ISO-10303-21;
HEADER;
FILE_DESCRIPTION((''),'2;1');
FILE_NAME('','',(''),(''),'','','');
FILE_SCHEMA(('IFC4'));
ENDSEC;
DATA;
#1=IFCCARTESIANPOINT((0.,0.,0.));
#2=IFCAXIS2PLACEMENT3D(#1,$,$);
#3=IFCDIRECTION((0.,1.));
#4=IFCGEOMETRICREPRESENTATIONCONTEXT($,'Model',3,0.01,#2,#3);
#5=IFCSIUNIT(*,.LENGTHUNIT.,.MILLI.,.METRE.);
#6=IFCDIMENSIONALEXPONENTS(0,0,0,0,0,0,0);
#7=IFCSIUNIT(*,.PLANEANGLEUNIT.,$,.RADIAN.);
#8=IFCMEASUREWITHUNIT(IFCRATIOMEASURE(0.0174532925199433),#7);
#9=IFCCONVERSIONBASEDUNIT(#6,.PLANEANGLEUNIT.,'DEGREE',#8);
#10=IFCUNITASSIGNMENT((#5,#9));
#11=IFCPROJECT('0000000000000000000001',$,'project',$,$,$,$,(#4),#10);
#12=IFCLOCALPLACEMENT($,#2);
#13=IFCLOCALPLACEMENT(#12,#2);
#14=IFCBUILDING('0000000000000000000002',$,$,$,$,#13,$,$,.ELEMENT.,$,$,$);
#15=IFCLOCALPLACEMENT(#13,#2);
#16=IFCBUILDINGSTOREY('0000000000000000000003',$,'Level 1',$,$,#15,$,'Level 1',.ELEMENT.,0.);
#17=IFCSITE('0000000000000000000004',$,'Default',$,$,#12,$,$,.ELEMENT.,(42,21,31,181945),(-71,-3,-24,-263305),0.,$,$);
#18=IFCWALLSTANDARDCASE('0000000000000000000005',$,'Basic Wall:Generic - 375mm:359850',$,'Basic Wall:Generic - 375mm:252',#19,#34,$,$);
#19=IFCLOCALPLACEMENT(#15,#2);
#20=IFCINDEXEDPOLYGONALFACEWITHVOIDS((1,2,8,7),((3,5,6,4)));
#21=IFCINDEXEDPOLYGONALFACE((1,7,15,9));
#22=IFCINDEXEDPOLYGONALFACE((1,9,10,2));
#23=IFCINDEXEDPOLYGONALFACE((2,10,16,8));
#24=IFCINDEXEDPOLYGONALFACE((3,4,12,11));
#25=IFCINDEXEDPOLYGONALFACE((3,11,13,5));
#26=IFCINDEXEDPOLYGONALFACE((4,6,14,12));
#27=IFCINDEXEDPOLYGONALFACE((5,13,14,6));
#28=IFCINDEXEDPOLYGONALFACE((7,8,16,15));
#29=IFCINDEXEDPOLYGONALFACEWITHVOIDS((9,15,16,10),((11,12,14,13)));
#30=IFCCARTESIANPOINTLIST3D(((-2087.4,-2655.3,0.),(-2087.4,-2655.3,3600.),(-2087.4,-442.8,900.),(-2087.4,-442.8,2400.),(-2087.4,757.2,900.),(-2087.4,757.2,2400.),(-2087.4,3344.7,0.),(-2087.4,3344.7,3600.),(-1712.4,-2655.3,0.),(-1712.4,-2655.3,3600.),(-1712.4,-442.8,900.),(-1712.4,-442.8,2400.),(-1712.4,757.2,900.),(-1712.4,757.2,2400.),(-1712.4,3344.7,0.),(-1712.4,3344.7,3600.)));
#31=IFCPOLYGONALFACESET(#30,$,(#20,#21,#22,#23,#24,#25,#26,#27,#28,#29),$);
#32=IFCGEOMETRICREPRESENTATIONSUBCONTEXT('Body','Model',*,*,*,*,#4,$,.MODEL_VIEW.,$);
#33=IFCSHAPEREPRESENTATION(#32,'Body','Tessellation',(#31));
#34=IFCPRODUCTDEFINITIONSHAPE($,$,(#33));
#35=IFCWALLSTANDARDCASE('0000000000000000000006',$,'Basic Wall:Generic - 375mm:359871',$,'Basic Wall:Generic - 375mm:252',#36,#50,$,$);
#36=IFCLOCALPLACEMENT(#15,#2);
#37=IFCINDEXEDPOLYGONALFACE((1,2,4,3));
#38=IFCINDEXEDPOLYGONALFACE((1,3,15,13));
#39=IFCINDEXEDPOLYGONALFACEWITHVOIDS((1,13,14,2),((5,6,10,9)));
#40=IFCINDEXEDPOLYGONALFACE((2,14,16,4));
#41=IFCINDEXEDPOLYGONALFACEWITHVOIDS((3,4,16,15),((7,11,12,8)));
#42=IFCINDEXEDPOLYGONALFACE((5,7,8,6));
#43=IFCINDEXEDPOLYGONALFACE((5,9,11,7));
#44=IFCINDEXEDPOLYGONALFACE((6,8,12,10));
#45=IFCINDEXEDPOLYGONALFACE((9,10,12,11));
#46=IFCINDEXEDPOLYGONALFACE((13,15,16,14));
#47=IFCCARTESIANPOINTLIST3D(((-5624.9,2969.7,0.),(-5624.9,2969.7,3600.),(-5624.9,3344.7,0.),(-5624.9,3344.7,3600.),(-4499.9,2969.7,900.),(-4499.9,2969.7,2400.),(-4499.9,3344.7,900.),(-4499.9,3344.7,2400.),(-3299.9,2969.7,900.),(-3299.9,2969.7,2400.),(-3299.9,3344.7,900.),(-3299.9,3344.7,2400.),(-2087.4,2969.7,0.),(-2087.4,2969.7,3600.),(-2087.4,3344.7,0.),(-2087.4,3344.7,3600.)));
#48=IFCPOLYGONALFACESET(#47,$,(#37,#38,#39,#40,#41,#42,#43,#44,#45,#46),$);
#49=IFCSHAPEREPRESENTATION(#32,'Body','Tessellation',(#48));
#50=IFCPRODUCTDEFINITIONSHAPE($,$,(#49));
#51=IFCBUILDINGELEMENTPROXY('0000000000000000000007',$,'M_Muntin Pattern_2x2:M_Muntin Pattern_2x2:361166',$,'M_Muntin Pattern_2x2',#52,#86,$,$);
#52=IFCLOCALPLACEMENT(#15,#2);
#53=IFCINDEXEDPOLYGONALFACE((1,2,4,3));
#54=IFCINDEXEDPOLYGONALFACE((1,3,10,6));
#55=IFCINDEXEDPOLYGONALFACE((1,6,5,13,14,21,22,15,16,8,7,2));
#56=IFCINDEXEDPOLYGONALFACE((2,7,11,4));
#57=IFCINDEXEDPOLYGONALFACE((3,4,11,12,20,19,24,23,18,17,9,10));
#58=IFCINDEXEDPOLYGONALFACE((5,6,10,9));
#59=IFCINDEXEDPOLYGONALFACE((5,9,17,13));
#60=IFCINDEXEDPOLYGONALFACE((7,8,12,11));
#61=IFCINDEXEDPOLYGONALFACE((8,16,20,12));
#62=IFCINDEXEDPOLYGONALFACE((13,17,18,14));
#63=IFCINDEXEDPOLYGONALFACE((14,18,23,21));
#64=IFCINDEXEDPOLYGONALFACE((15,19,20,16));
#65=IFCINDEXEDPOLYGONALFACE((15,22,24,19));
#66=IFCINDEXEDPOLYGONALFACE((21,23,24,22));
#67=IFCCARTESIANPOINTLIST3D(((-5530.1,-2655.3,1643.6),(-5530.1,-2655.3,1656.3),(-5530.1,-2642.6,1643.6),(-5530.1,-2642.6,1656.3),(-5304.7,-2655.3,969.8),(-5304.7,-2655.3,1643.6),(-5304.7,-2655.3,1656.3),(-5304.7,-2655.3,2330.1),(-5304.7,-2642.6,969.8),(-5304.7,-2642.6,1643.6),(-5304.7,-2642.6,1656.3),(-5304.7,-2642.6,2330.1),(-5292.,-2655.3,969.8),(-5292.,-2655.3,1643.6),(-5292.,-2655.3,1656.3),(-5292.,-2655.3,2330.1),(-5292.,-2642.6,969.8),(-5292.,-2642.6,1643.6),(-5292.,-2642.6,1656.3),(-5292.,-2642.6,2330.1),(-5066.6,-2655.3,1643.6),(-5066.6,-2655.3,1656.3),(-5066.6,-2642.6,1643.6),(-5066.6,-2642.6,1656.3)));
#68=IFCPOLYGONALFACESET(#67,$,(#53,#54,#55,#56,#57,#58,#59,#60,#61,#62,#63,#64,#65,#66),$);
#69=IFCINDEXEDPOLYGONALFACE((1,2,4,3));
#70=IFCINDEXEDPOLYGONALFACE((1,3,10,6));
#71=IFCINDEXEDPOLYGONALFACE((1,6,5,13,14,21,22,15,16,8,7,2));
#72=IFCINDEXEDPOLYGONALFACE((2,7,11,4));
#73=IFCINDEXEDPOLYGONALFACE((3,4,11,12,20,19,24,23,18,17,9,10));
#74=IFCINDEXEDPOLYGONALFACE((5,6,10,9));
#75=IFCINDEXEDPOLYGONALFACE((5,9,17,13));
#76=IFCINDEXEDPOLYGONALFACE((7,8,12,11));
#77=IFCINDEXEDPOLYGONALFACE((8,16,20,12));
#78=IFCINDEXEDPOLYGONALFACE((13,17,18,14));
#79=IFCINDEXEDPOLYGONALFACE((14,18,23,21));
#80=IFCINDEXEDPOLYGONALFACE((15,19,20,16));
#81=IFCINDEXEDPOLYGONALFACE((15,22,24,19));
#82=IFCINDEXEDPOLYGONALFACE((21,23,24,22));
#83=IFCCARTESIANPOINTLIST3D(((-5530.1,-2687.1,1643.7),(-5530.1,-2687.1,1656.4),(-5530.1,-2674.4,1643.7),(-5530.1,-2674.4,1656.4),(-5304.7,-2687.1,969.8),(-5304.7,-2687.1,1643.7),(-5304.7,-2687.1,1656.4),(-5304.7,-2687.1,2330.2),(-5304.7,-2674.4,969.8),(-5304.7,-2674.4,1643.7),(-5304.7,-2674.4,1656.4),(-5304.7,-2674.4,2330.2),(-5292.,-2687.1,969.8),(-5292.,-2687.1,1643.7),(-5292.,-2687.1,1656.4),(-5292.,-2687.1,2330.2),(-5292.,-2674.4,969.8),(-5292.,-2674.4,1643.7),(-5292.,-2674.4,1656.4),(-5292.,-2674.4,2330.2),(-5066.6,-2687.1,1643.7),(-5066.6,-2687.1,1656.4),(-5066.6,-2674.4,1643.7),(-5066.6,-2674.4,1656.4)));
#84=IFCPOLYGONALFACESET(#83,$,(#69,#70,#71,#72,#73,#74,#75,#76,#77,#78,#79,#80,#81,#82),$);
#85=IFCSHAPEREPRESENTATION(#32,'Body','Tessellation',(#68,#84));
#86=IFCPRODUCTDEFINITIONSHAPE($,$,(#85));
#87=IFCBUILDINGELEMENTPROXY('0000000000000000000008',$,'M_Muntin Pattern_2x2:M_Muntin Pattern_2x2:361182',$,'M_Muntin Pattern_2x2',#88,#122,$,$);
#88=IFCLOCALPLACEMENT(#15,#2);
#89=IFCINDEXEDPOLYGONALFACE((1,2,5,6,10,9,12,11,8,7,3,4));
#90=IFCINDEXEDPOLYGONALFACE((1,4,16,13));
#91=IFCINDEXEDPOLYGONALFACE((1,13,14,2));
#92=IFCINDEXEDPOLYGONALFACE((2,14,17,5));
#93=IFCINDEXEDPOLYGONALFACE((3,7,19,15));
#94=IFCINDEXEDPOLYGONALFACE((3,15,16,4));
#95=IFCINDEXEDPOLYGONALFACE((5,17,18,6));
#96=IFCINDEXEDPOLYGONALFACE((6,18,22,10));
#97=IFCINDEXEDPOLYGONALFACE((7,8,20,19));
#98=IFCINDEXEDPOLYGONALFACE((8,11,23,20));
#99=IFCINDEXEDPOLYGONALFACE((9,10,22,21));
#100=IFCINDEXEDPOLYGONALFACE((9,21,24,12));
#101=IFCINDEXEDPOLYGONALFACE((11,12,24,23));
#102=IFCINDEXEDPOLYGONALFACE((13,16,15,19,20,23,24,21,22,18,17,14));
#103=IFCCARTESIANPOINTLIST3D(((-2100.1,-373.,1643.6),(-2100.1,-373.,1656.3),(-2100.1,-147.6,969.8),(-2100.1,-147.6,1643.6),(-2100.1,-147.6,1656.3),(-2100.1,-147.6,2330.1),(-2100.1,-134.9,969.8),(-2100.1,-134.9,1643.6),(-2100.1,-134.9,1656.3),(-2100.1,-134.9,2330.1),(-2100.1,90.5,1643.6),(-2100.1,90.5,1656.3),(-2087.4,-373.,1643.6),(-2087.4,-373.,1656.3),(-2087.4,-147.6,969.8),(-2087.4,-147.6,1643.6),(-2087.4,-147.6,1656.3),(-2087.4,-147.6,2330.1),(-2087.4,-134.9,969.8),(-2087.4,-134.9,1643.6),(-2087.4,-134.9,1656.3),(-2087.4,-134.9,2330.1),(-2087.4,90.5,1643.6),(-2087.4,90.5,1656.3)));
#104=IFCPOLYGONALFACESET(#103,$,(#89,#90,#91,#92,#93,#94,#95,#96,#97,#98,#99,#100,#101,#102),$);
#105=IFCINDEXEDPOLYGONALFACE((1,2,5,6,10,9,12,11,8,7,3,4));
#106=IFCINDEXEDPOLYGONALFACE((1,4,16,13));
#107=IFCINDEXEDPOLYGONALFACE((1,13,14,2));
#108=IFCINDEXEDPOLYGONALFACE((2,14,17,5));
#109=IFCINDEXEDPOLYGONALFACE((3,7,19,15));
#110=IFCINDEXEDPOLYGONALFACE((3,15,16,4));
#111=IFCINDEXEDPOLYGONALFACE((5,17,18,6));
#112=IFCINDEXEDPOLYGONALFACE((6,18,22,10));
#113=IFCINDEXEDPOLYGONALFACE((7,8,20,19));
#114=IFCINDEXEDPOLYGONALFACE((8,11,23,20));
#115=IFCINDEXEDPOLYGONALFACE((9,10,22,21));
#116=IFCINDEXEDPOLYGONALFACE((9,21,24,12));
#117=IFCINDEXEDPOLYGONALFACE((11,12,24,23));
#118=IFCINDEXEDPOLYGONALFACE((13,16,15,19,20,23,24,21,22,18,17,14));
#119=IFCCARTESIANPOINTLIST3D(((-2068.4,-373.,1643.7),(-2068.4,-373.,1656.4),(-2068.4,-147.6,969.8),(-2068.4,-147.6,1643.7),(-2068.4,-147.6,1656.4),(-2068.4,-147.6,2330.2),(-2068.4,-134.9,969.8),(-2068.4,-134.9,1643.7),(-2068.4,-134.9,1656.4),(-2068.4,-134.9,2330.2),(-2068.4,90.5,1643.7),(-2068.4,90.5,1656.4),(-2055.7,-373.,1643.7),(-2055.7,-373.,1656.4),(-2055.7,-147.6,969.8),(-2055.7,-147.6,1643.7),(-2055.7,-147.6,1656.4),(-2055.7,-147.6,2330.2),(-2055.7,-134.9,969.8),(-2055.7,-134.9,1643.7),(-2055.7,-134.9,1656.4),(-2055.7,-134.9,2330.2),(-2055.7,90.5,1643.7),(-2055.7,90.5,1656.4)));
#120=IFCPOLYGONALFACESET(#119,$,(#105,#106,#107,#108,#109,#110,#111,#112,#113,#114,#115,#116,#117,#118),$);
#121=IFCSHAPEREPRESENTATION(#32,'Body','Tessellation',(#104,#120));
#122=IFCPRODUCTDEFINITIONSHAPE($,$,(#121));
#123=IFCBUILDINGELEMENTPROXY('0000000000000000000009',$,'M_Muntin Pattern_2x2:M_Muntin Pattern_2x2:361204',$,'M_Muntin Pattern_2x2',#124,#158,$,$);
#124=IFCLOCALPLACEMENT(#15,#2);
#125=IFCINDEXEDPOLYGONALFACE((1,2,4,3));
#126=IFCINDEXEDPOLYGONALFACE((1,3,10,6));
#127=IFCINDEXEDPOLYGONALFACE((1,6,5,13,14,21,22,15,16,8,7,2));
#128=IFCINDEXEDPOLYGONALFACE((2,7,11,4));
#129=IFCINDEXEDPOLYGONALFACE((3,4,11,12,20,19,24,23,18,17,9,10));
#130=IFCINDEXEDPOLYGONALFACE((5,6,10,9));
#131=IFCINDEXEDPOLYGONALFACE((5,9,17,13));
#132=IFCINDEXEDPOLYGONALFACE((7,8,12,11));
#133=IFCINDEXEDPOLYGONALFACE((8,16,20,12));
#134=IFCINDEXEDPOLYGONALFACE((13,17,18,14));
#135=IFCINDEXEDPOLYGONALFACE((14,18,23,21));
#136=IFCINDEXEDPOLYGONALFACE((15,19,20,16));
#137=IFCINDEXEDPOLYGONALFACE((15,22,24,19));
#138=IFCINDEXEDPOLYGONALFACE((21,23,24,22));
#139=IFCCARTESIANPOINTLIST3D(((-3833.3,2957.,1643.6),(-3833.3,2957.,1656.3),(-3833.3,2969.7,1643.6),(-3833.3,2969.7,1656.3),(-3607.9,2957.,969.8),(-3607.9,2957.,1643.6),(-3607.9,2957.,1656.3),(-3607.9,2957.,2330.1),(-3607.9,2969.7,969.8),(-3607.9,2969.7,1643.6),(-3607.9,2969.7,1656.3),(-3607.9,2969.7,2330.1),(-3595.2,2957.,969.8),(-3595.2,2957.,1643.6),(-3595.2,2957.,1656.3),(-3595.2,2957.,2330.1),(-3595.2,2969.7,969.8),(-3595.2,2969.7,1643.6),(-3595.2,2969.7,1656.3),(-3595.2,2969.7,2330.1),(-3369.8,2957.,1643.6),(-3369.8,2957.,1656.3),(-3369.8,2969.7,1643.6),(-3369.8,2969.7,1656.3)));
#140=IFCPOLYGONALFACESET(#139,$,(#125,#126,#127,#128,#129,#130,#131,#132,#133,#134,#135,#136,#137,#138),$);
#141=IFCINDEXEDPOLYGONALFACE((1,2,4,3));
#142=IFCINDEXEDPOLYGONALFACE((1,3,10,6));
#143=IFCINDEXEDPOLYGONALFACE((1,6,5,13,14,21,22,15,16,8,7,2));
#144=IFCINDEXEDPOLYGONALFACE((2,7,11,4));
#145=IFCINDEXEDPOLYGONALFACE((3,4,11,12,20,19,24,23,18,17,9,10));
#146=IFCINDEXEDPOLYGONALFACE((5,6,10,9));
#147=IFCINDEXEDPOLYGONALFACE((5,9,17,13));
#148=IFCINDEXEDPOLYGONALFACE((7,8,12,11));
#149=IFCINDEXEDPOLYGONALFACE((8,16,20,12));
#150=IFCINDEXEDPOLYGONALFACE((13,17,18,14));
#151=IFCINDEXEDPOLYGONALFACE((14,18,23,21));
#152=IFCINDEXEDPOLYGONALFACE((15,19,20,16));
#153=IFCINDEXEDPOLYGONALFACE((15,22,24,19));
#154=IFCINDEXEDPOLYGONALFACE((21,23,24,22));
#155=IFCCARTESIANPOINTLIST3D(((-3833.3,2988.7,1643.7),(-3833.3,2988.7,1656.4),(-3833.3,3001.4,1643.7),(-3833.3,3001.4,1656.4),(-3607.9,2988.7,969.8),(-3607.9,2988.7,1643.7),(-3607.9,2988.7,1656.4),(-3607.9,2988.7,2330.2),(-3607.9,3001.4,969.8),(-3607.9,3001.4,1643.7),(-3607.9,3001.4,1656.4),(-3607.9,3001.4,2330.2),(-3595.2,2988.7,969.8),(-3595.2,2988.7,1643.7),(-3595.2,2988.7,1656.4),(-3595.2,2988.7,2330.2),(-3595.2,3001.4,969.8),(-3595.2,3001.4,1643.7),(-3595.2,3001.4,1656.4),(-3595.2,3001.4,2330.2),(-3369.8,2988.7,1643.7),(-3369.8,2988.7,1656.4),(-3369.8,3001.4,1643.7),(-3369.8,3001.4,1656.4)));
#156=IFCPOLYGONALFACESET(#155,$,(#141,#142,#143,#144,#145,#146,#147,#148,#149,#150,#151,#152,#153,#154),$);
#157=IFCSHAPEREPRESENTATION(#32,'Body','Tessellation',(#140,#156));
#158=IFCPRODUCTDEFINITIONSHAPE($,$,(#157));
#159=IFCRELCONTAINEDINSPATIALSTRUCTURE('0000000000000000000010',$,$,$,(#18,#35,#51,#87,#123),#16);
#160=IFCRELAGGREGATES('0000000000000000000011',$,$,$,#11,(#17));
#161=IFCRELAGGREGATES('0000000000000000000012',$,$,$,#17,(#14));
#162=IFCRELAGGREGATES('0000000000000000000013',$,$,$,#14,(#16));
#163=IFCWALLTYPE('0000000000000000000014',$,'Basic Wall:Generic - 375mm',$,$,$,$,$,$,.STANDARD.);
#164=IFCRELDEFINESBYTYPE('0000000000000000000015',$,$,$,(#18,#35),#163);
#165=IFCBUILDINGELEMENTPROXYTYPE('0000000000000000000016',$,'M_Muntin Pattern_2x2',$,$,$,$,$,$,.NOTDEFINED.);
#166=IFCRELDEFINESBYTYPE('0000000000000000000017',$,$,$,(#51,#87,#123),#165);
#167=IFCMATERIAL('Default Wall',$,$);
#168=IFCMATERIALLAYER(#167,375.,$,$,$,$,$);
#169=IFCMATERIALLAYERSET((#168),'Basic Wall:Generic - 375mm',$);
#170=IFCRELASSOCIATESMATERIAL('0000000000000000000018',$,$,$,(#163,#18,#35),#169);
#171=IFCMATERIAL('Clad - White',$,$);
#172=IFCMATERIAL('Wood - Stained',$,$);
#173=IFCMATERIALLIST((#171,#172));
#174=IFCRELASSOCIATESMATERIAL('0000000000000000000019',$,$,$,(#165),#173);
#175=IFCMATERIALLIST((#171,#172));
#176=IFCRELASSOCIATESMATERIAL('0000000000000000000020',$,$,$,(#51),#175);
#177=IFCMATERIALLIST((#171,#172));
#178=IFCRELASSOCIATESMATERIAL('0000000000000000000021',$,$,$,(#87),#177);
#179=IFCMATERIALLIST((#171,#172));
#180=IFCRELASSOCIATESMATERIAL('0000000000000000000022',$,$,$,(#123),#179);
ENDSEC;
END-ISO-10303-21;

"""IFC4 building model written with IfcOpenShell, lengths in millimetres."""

from ifc_helpers import new_model, entity, si_unit, converted_unit, direction, frame, frame_2d, origin, place, context, subcontext, project, spatial, polyline, rectangle, outline, extrude, clip, bounded_halfspace, source, transform, mapped, material, material_list, layer, layer_set, layer_usage, type_object, type_shapes, element, save


model = new_model("IFC4")

# Units and contexts
model_context = context("Model", 3, precision=0.01, world=origin(), true_north=direction((0.0, 1.0)))
body_context = subcontext(model_context, "Body", "Model", "MODEL_VIEW")
ifc_project = project(units=[si_unit("LENGTHUNIT", "METRE", prefix="MILLI"), converted_unit("PLANEANGLEUNIT", "DEGREE", entity("IfcRatioMeasure", 0.0174532925199433), si_unit("PLANEANGLEUNIT", "RADIAN"), dimensions=[0, 0, 0, 0, 0, 0, 0])], contexts=[model_context])

# Site, building, storey
site_placement = place(None, origin())
site = spatial("IfcSite", under=ifc_project, at=site_placement, Name="Default", CompositionType="ELEMENT", RefLatitude=(42, 21, 31, 181945), RefLongitude=(-71, -3, -24, -263305), RefElevation=0.0)
building_placement = place(site_placement, origin())
building = spatial("IfcBuilding", under=site, at=building_placement, CompositionType="ELEMENT")
storey_placement = place(building_placement, origin())
storey = spatial("IfcBuildingStorey", under=building, at=storey_placement, Name="Level 1", LongName="Level 1", CompositionType="ELEMENT", Elevation=0.0)

# Walls, openings
ifc_material_1 = material(Name="Default Wall")
ifc_layer = layer(ifc_material_1, 375.0)
ifc_layer_set = layer_set([ifc_layer], Name="Basic Wall:Generic - 375mm")
ifc_layer_usage_1 = layer_usage(ifc_layer_set, "AXIS2", "NEGATIVE", 187.5)
wall_type = type_object("IfcWallType", Name="Basic Wall:Generic - 375mm", PredefinedType="STANDARD", material=ifc_layer_set)
wall_1_placement = place(storey_placement, frame((-1899.9, -2655.3, 0.0), z_axis=(0.0, 0.0, 1.0), x_axis=(0.0, 1.0, 0.0)))
wall_1 = element("IfcWallStandardCase", 1, at=wall_1_placement, inside=storey, type_object=wall_type, material=ifc_layer_usage_1, Name="Basic Wall:Generic - 375mm:359850", ObjectType="Basic Wall:Generic - 375mm:252", context=body_context, shape_type="Clipping", body=[
    clip(extrude(rectangle(XDim=6000.0, YDim=375.0, at=frame_2d((3000.0, 0.0), x_axis=(-1.0, 0.0))), origin(), (0.0, 0.0, 1.0), 3600.0), bounded_halfspace(frame((0.0, -187.5, 3600.0), z_axis=(0.0, 0.0, -1.0), x_axis=(0.0, -1.0, 0.0)), True, frame((0.0, -187.5, 3600.0)), polyline([(0.0, 0.0), (6000.0, 0.0), (6000.0, 375.0), (5625.0, 375.0), (0.0, 375.0), (0.0, 0.0)]))),
])
opening_1_placement = place(wall_1_placement, frame((2212.5, -187.5, 900.0)))
element("IfcOpeningElement", 2, at=opening_1_placement, cuts=wall_1, ObjectType="Opening", context=body_context, shape_type="SweptSolid", body=[
    extrude(rectangle(XDim=1500.0, YDim=1200.0, at=frame_2d((750.0, 600.0), x_axis=(-1.0, 0.0))), frame((0.0, 0.0, 0.0), z_axis=(0.0, 1.0, 0.0), x_axis=(0.0, 0.0, 1.0)), (0.0, 0.0, 1.0), 375.0),
])
ifc_layer_usage_2 = layer_usage(ifc_layer_set, "AXIS2", "NEGATIVE", 187.5)
wall_2_placement = place(storey_placement, frame((-2087.4, 3157.2, 0.0), z_axis=(0.0, 0.0, 1.0), x_axis=(-1.0, 0.0, 0.0)))
wall_2 = element("IfcWallStandardCase", 3, at=wall_2_placement, inside=storey, type_object=wall_type, material=ifc_layer_usage_2, Name="Basic Wall:Generic - 375mm:359871", ObjectType="Basic Wall:Generic - 375mm:252", context=body_context, shape_type="Clipping", body=[
    clip(extrude(rectangle(XDim=3537.5, YDim=375.0, at=frame_2d((1768.8, 0.0), x_axis=(-1.0, 0.0))), origin(), (0.0, 0.0, 1.0), 3600.0), bounded_halfspace(frame((0.0, -187.5, 3600.0), z_axis=(0.0, 0.0, -1.0), x_axis=(-1.0, 0.0, 0.0)), True, frame((0.0, -187.5, 3600.0)), polyline([(0.0, 0.0), (3537.5, 0.0), (3537.5, 375.0), (0.0, 375.0), (0.0, 0.0)]))),
])
opening_2_placement = place(wall_2_placement, frame((1212.5, -187.5, 900.0)))
element("IfcOpeningElement", 4, at=opening_2_placement, cuts=wall_2, ObjectType="Opening", context=body_context, shape_type="SweptSolid", body=[
    extrude(rectangle(XDim=1500.0, YDim=1200.0, at=frame_2d((750.0, 600.0), x_axis=(-1.0, 0.0))), frame((0.0, 0.0, 0.0), z_axis=(0.0, 1.0, 0.0), x_axis=(0.0, 0.0, 1.0)), (0.0, 0.0, 1.0), 375.0),
])

# Building element proxies
ifc_material_2 = material(Name="Clad - White")
ifc_material_3 = material(Name="Wood - Stained")
ifc_material_list_1 = material_list([ifc_material_2, ifc_material_3])
ifc_material_list_2 = material_list([ifc_material_2, ifc_material_3])
building_element_proxy_type_1 = type_object("IfcBuildingElementProxyType", Name="M_Muntin Pattern_2x2", PredefinedType="NOTDEFINED", material=ifc_material_list_2)
shared_shape_1 = source(origin(), body_context, "Body", "SweptSolid", [
    extrude(outline(polyline([(6.4, -6.4), (680.1, -6.4), (680.1, 6.3), (6.4, 6.3), (6.4, 231.7), (-6.3, 231.7), (-6.3, 6.3), (-680.2, 6.3), (-680.2, -6.4), (-6.3, -6.4), (-6.3, -231.7), (6.4, -231.7), (6.4, -6.4)])), frame((0.0, 9.5, 680.1), z_axis=(0.0, 1.0, 0.0), x_axis=(0.0, 0.0, 1.0)), (0.0, 0.0, 1.0), 12.7),
    extrude(outline(polyline([(6.4, -6.4), (680.2, -6.4), (680.2, 6.3), (6.4, 6.3), (6.4, 231.7), (-6.3, 231.7), (-6.3, 6.3), (-680.2, 6.3), (-680.2, -6.4), (-6.3, -6.4), (-6.3, -231.7), (6.4, -231.7), (6.4, -6.4)])), frame((0.0, -22.2, 680.2), z_axis=(0.0, 1.0, 0.0), x_axis=(0.0, 0.0, 1.0)), (0.0, 0.0, 1.0), 12.7),
])
type_shapes(building_element_proxy_type_1, [shared_shape_1])
proxy_1_placement = place(storey_placement, frame((-5298.4, -2664.9, 969.8)))
element("IfcBuildingElementProxy", 5, at=proxy_1_placement, inside=storey, type_object=building_element_proxy_type_1, material=ifc_material_list_1, Name="M_Muntin Pattern_2x2:M_Muntin Pattern_2x2:361166", ObjectType="M_Muntin Pattern_2x2", context=body_context, shape_type="MappedRepresentation", body=[
    mapped(shared_shape_1, transform((0.0, 0.0, 0.0), scale=1.0)),
])
ifc_material_list_3 = material_list([ifc_material_2, ifc_material_3])
proxy_2_placement = place(storey_placement, frame((-2077.9, -141.3, 969.8), z_axis=(0.0, 0.0, 1.0), x_axis=(0.0, 1.0, 0.0)))
element("IfcBuildingElementProxy", 6, at=proxy_2_placement, inside=storey, type_object=building_element_proxy_type_1, material=ifc_material_list_3, Name="M_Muntin Pattern_2x2:M_Muntin Pattern_2x2:361182", ObjectType="M_Muntin Pattern_2x2", context=body_context, shape_type="MappedRepresentation", body=[
    mapped(shared_shape_1, transform((0.0, 0.0, 0.0), scale=1.0)),
])
ifc_material_list_4 = material_list([ifc_material_2, ifc_material_3])
proxy_3_placement = place(storey_placement, frame((-3601.5, 2979.2, 969.8), z_axis=(0.0, 0.0, 1.0), x_axis=(-1.0, 0.0, 0.0)))
element("IfcBuildingElementProxy", 7, at=proxy_3_placement, inside=storey, type_object=building_element_proxy_type_1, material=ifc_material_list_4, Name="M_Muntin Pattern_2x2:M_Muntin Pattern_2x2:361204", ObjectType="M_Muntin Pattern_2x2", context=body_context, shape_type="MappedRepresentation", body=[
    mapped(shared_shape_1, transform((0.0, 0.0, 0.0), scale=1.0)),
])

save(model, "model.ifc")
